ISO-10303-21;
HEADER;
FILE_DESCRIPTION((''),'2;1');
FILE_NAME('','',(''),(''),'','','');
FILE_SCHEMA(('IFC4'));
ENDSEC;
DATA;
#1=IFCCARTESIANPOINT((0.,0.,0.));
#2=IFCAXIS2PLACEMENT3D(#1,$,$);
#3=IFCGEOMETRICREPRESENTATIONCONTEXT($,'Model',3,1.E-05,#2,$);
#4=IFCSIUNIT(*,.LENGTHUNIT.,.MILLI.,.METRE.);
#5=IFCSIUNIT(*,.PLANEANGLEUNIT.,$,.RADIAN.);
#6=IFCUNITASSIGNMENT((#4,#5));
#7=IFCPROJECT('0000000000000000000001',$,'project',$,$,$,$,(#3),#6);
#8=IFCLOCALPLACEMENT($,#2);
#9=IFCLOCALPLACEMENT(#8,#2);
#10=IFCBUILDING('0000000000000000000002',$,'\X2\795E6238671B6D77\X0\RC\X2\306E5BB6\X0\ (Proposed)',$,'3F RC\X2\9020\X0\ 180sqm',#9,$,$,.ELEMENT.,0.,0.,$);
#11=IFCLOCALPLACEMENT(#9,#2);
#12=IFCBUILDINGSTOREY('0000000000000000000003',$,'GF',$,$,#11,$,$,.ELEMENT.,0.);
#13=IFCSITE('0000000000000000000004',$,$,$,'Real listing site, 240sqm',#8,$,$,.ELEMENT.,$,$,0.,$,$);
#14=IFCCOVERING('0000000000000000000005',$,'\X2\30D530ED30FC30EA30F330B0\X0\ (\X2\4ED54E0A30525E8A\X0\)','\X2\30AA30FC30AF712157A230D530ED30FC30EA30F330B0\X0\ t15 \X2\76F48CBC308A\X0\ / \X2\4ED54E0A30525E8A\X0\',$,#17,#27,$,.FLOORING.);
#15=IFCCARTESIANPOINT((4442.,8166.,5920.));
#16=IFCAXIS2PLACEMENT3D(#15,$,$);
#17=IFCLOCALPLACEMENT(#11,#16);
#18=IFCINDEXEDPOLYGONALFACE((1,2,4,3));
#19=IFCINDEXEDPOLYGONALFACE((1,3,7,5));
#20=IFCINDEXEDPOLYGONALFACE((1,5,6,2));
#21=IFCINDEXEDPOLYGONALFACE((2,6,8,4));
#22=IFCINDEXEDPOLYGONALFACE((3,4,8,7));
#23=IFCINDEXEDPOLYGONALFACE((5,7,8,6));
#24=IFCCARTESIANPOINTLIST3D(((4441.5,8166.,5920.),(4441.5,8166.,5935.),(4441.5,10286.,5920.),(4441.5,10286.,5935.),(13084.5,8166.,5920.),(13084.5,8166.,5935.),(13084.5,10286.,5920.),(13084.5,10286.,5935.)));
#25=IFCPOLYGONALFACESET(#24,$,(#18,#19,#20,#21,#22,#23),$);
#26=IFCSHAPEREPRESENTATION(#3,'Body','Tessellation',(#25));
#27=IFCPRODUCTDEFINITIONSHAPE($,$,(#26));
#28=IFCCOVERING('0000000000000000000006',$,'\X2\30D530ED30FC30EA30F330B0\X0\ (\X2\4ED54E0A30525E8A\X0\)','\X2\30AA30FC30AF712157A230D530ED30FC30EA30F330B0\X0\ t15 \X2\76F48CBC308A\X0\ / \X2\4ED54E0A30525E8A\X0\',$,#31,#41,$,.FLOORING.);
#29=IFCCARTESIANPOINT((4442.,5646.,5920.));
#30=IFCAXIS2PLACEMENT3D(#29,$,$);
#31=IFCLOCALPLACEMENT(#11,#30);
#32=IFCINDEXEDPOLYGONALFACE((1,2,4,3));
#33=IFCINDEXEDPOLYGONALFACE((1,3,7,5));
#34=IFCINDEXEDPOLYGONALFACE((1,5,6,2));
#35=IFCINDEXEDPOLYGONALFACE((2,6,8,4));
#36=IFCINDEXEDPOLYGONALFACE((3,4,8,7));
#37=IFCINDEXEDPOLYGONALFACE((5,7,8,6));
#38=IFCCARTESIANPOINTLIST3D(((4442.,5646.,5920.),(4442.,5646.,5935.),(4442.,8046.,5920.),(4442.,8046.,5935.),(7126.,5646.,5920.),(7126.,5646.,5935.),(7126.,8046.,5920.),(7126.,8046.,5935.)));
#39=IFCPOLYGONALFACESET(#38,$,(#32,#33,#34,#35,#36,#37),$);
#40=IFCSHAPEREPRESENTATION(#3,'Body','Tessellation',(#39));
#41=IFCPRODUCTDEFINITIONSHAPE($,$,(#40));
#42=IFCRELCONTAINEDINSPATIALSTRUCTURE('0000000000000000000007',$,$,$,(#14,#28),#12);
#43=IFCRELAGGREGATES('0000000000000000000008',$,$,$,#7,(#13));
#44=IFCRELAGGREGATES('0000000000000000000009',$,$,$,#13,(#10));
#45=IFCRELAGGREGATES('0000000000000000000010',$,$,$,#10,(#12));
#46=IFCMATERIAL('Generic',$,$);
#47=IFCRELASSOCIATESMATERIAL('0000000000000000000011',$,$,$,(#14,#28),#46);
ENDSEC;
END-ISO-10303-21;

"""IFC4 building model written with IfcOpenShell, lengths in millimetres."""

from ifc_helpers import new_model, si_unit, frame, frame_2d, origin, place, context, project, spatial, rectangle, extrude, material, element, save


model = new_model("IFC4")

# Units and contexts
model_context = context("Model", 3, precision=1e-05, world=origin())
ifc_project = project(units=[si_unit("LENGTHUNIT", "METRE", prefix="MILLI"), si_unit("PLANEANGLEUNIT", "RADIAN")], contexts=[model_context])

# Site, building, storey
site_placement = place(None, origin())
site = spatial("IfcSite", under=ifc_project, at=site_placement, ObjectType="Real listing site, 240sqm", CompositionType="ELEMENT", RefElevation=0.0)
building_placement = place(site_placement, origin())
building = spatial("IfcBuilding", under=site, at=building_placement, Name="神戸望海RCの家 (Proposed)", ObjectType="3F RC造 180sqm", CompositionType="ELEMENT", ElevationOfRefHeight=0.0, ElevationOfTerrain=0.0)
storey_placement = place(building_placement, origin())
storey = spatial("IfcBuildingStorey", under=building, at=storey_placement, Name="GF", CompositionType="ELEMENT", Elevation=0.0)

# Coverings
ifc_material_1 = material(Name="Generic")
covering_1_placement = place(storey_placement, frame((4442.0, 8166.0, 5920.0)))
element("IfcCovering", 1, at=covering_1_placement, inside=storey, material=ifc_material_1, Name="フローリング (仕上げ床)", Description="オーク無垢フローリング t15 直貼り / 仕上げ床", PredefinedType="FLOORING", context=model_context, shape_type="SweptSolid", body=[
    extrude(rectangle(XDim=8643.0, YDim=2120.0, at=frame_2d((4321.0, 1060.0))), frame((4442.0, 8166.0, 5920.0)), (0.0, 0.0, 1.0), 15.0),
])
covering_2_placement = place(storey_placement, frame((4442.0, 5646.0, 5920.0)))
element("IfcCovering", 2, at=covering_2_placement, inside=storey, material=ifc_material_1, Name="フローリング (仕上げ床)", Description="オーク無垢フローリング t15 直貼り / 仕上げ床", PredefinedType="FLOORING", context=model_context, shape_type="SweptSolid", body=[
    extrude(rectangle(XDim=2684.0, YDim=2400.0, at=frame_2d((1342.0, 1200.0))), frame((4442.0, 5646.0, 5920.0)), (0.0, 0.0, 1.0), 15.0),
])

save(model, "model.ifc")
